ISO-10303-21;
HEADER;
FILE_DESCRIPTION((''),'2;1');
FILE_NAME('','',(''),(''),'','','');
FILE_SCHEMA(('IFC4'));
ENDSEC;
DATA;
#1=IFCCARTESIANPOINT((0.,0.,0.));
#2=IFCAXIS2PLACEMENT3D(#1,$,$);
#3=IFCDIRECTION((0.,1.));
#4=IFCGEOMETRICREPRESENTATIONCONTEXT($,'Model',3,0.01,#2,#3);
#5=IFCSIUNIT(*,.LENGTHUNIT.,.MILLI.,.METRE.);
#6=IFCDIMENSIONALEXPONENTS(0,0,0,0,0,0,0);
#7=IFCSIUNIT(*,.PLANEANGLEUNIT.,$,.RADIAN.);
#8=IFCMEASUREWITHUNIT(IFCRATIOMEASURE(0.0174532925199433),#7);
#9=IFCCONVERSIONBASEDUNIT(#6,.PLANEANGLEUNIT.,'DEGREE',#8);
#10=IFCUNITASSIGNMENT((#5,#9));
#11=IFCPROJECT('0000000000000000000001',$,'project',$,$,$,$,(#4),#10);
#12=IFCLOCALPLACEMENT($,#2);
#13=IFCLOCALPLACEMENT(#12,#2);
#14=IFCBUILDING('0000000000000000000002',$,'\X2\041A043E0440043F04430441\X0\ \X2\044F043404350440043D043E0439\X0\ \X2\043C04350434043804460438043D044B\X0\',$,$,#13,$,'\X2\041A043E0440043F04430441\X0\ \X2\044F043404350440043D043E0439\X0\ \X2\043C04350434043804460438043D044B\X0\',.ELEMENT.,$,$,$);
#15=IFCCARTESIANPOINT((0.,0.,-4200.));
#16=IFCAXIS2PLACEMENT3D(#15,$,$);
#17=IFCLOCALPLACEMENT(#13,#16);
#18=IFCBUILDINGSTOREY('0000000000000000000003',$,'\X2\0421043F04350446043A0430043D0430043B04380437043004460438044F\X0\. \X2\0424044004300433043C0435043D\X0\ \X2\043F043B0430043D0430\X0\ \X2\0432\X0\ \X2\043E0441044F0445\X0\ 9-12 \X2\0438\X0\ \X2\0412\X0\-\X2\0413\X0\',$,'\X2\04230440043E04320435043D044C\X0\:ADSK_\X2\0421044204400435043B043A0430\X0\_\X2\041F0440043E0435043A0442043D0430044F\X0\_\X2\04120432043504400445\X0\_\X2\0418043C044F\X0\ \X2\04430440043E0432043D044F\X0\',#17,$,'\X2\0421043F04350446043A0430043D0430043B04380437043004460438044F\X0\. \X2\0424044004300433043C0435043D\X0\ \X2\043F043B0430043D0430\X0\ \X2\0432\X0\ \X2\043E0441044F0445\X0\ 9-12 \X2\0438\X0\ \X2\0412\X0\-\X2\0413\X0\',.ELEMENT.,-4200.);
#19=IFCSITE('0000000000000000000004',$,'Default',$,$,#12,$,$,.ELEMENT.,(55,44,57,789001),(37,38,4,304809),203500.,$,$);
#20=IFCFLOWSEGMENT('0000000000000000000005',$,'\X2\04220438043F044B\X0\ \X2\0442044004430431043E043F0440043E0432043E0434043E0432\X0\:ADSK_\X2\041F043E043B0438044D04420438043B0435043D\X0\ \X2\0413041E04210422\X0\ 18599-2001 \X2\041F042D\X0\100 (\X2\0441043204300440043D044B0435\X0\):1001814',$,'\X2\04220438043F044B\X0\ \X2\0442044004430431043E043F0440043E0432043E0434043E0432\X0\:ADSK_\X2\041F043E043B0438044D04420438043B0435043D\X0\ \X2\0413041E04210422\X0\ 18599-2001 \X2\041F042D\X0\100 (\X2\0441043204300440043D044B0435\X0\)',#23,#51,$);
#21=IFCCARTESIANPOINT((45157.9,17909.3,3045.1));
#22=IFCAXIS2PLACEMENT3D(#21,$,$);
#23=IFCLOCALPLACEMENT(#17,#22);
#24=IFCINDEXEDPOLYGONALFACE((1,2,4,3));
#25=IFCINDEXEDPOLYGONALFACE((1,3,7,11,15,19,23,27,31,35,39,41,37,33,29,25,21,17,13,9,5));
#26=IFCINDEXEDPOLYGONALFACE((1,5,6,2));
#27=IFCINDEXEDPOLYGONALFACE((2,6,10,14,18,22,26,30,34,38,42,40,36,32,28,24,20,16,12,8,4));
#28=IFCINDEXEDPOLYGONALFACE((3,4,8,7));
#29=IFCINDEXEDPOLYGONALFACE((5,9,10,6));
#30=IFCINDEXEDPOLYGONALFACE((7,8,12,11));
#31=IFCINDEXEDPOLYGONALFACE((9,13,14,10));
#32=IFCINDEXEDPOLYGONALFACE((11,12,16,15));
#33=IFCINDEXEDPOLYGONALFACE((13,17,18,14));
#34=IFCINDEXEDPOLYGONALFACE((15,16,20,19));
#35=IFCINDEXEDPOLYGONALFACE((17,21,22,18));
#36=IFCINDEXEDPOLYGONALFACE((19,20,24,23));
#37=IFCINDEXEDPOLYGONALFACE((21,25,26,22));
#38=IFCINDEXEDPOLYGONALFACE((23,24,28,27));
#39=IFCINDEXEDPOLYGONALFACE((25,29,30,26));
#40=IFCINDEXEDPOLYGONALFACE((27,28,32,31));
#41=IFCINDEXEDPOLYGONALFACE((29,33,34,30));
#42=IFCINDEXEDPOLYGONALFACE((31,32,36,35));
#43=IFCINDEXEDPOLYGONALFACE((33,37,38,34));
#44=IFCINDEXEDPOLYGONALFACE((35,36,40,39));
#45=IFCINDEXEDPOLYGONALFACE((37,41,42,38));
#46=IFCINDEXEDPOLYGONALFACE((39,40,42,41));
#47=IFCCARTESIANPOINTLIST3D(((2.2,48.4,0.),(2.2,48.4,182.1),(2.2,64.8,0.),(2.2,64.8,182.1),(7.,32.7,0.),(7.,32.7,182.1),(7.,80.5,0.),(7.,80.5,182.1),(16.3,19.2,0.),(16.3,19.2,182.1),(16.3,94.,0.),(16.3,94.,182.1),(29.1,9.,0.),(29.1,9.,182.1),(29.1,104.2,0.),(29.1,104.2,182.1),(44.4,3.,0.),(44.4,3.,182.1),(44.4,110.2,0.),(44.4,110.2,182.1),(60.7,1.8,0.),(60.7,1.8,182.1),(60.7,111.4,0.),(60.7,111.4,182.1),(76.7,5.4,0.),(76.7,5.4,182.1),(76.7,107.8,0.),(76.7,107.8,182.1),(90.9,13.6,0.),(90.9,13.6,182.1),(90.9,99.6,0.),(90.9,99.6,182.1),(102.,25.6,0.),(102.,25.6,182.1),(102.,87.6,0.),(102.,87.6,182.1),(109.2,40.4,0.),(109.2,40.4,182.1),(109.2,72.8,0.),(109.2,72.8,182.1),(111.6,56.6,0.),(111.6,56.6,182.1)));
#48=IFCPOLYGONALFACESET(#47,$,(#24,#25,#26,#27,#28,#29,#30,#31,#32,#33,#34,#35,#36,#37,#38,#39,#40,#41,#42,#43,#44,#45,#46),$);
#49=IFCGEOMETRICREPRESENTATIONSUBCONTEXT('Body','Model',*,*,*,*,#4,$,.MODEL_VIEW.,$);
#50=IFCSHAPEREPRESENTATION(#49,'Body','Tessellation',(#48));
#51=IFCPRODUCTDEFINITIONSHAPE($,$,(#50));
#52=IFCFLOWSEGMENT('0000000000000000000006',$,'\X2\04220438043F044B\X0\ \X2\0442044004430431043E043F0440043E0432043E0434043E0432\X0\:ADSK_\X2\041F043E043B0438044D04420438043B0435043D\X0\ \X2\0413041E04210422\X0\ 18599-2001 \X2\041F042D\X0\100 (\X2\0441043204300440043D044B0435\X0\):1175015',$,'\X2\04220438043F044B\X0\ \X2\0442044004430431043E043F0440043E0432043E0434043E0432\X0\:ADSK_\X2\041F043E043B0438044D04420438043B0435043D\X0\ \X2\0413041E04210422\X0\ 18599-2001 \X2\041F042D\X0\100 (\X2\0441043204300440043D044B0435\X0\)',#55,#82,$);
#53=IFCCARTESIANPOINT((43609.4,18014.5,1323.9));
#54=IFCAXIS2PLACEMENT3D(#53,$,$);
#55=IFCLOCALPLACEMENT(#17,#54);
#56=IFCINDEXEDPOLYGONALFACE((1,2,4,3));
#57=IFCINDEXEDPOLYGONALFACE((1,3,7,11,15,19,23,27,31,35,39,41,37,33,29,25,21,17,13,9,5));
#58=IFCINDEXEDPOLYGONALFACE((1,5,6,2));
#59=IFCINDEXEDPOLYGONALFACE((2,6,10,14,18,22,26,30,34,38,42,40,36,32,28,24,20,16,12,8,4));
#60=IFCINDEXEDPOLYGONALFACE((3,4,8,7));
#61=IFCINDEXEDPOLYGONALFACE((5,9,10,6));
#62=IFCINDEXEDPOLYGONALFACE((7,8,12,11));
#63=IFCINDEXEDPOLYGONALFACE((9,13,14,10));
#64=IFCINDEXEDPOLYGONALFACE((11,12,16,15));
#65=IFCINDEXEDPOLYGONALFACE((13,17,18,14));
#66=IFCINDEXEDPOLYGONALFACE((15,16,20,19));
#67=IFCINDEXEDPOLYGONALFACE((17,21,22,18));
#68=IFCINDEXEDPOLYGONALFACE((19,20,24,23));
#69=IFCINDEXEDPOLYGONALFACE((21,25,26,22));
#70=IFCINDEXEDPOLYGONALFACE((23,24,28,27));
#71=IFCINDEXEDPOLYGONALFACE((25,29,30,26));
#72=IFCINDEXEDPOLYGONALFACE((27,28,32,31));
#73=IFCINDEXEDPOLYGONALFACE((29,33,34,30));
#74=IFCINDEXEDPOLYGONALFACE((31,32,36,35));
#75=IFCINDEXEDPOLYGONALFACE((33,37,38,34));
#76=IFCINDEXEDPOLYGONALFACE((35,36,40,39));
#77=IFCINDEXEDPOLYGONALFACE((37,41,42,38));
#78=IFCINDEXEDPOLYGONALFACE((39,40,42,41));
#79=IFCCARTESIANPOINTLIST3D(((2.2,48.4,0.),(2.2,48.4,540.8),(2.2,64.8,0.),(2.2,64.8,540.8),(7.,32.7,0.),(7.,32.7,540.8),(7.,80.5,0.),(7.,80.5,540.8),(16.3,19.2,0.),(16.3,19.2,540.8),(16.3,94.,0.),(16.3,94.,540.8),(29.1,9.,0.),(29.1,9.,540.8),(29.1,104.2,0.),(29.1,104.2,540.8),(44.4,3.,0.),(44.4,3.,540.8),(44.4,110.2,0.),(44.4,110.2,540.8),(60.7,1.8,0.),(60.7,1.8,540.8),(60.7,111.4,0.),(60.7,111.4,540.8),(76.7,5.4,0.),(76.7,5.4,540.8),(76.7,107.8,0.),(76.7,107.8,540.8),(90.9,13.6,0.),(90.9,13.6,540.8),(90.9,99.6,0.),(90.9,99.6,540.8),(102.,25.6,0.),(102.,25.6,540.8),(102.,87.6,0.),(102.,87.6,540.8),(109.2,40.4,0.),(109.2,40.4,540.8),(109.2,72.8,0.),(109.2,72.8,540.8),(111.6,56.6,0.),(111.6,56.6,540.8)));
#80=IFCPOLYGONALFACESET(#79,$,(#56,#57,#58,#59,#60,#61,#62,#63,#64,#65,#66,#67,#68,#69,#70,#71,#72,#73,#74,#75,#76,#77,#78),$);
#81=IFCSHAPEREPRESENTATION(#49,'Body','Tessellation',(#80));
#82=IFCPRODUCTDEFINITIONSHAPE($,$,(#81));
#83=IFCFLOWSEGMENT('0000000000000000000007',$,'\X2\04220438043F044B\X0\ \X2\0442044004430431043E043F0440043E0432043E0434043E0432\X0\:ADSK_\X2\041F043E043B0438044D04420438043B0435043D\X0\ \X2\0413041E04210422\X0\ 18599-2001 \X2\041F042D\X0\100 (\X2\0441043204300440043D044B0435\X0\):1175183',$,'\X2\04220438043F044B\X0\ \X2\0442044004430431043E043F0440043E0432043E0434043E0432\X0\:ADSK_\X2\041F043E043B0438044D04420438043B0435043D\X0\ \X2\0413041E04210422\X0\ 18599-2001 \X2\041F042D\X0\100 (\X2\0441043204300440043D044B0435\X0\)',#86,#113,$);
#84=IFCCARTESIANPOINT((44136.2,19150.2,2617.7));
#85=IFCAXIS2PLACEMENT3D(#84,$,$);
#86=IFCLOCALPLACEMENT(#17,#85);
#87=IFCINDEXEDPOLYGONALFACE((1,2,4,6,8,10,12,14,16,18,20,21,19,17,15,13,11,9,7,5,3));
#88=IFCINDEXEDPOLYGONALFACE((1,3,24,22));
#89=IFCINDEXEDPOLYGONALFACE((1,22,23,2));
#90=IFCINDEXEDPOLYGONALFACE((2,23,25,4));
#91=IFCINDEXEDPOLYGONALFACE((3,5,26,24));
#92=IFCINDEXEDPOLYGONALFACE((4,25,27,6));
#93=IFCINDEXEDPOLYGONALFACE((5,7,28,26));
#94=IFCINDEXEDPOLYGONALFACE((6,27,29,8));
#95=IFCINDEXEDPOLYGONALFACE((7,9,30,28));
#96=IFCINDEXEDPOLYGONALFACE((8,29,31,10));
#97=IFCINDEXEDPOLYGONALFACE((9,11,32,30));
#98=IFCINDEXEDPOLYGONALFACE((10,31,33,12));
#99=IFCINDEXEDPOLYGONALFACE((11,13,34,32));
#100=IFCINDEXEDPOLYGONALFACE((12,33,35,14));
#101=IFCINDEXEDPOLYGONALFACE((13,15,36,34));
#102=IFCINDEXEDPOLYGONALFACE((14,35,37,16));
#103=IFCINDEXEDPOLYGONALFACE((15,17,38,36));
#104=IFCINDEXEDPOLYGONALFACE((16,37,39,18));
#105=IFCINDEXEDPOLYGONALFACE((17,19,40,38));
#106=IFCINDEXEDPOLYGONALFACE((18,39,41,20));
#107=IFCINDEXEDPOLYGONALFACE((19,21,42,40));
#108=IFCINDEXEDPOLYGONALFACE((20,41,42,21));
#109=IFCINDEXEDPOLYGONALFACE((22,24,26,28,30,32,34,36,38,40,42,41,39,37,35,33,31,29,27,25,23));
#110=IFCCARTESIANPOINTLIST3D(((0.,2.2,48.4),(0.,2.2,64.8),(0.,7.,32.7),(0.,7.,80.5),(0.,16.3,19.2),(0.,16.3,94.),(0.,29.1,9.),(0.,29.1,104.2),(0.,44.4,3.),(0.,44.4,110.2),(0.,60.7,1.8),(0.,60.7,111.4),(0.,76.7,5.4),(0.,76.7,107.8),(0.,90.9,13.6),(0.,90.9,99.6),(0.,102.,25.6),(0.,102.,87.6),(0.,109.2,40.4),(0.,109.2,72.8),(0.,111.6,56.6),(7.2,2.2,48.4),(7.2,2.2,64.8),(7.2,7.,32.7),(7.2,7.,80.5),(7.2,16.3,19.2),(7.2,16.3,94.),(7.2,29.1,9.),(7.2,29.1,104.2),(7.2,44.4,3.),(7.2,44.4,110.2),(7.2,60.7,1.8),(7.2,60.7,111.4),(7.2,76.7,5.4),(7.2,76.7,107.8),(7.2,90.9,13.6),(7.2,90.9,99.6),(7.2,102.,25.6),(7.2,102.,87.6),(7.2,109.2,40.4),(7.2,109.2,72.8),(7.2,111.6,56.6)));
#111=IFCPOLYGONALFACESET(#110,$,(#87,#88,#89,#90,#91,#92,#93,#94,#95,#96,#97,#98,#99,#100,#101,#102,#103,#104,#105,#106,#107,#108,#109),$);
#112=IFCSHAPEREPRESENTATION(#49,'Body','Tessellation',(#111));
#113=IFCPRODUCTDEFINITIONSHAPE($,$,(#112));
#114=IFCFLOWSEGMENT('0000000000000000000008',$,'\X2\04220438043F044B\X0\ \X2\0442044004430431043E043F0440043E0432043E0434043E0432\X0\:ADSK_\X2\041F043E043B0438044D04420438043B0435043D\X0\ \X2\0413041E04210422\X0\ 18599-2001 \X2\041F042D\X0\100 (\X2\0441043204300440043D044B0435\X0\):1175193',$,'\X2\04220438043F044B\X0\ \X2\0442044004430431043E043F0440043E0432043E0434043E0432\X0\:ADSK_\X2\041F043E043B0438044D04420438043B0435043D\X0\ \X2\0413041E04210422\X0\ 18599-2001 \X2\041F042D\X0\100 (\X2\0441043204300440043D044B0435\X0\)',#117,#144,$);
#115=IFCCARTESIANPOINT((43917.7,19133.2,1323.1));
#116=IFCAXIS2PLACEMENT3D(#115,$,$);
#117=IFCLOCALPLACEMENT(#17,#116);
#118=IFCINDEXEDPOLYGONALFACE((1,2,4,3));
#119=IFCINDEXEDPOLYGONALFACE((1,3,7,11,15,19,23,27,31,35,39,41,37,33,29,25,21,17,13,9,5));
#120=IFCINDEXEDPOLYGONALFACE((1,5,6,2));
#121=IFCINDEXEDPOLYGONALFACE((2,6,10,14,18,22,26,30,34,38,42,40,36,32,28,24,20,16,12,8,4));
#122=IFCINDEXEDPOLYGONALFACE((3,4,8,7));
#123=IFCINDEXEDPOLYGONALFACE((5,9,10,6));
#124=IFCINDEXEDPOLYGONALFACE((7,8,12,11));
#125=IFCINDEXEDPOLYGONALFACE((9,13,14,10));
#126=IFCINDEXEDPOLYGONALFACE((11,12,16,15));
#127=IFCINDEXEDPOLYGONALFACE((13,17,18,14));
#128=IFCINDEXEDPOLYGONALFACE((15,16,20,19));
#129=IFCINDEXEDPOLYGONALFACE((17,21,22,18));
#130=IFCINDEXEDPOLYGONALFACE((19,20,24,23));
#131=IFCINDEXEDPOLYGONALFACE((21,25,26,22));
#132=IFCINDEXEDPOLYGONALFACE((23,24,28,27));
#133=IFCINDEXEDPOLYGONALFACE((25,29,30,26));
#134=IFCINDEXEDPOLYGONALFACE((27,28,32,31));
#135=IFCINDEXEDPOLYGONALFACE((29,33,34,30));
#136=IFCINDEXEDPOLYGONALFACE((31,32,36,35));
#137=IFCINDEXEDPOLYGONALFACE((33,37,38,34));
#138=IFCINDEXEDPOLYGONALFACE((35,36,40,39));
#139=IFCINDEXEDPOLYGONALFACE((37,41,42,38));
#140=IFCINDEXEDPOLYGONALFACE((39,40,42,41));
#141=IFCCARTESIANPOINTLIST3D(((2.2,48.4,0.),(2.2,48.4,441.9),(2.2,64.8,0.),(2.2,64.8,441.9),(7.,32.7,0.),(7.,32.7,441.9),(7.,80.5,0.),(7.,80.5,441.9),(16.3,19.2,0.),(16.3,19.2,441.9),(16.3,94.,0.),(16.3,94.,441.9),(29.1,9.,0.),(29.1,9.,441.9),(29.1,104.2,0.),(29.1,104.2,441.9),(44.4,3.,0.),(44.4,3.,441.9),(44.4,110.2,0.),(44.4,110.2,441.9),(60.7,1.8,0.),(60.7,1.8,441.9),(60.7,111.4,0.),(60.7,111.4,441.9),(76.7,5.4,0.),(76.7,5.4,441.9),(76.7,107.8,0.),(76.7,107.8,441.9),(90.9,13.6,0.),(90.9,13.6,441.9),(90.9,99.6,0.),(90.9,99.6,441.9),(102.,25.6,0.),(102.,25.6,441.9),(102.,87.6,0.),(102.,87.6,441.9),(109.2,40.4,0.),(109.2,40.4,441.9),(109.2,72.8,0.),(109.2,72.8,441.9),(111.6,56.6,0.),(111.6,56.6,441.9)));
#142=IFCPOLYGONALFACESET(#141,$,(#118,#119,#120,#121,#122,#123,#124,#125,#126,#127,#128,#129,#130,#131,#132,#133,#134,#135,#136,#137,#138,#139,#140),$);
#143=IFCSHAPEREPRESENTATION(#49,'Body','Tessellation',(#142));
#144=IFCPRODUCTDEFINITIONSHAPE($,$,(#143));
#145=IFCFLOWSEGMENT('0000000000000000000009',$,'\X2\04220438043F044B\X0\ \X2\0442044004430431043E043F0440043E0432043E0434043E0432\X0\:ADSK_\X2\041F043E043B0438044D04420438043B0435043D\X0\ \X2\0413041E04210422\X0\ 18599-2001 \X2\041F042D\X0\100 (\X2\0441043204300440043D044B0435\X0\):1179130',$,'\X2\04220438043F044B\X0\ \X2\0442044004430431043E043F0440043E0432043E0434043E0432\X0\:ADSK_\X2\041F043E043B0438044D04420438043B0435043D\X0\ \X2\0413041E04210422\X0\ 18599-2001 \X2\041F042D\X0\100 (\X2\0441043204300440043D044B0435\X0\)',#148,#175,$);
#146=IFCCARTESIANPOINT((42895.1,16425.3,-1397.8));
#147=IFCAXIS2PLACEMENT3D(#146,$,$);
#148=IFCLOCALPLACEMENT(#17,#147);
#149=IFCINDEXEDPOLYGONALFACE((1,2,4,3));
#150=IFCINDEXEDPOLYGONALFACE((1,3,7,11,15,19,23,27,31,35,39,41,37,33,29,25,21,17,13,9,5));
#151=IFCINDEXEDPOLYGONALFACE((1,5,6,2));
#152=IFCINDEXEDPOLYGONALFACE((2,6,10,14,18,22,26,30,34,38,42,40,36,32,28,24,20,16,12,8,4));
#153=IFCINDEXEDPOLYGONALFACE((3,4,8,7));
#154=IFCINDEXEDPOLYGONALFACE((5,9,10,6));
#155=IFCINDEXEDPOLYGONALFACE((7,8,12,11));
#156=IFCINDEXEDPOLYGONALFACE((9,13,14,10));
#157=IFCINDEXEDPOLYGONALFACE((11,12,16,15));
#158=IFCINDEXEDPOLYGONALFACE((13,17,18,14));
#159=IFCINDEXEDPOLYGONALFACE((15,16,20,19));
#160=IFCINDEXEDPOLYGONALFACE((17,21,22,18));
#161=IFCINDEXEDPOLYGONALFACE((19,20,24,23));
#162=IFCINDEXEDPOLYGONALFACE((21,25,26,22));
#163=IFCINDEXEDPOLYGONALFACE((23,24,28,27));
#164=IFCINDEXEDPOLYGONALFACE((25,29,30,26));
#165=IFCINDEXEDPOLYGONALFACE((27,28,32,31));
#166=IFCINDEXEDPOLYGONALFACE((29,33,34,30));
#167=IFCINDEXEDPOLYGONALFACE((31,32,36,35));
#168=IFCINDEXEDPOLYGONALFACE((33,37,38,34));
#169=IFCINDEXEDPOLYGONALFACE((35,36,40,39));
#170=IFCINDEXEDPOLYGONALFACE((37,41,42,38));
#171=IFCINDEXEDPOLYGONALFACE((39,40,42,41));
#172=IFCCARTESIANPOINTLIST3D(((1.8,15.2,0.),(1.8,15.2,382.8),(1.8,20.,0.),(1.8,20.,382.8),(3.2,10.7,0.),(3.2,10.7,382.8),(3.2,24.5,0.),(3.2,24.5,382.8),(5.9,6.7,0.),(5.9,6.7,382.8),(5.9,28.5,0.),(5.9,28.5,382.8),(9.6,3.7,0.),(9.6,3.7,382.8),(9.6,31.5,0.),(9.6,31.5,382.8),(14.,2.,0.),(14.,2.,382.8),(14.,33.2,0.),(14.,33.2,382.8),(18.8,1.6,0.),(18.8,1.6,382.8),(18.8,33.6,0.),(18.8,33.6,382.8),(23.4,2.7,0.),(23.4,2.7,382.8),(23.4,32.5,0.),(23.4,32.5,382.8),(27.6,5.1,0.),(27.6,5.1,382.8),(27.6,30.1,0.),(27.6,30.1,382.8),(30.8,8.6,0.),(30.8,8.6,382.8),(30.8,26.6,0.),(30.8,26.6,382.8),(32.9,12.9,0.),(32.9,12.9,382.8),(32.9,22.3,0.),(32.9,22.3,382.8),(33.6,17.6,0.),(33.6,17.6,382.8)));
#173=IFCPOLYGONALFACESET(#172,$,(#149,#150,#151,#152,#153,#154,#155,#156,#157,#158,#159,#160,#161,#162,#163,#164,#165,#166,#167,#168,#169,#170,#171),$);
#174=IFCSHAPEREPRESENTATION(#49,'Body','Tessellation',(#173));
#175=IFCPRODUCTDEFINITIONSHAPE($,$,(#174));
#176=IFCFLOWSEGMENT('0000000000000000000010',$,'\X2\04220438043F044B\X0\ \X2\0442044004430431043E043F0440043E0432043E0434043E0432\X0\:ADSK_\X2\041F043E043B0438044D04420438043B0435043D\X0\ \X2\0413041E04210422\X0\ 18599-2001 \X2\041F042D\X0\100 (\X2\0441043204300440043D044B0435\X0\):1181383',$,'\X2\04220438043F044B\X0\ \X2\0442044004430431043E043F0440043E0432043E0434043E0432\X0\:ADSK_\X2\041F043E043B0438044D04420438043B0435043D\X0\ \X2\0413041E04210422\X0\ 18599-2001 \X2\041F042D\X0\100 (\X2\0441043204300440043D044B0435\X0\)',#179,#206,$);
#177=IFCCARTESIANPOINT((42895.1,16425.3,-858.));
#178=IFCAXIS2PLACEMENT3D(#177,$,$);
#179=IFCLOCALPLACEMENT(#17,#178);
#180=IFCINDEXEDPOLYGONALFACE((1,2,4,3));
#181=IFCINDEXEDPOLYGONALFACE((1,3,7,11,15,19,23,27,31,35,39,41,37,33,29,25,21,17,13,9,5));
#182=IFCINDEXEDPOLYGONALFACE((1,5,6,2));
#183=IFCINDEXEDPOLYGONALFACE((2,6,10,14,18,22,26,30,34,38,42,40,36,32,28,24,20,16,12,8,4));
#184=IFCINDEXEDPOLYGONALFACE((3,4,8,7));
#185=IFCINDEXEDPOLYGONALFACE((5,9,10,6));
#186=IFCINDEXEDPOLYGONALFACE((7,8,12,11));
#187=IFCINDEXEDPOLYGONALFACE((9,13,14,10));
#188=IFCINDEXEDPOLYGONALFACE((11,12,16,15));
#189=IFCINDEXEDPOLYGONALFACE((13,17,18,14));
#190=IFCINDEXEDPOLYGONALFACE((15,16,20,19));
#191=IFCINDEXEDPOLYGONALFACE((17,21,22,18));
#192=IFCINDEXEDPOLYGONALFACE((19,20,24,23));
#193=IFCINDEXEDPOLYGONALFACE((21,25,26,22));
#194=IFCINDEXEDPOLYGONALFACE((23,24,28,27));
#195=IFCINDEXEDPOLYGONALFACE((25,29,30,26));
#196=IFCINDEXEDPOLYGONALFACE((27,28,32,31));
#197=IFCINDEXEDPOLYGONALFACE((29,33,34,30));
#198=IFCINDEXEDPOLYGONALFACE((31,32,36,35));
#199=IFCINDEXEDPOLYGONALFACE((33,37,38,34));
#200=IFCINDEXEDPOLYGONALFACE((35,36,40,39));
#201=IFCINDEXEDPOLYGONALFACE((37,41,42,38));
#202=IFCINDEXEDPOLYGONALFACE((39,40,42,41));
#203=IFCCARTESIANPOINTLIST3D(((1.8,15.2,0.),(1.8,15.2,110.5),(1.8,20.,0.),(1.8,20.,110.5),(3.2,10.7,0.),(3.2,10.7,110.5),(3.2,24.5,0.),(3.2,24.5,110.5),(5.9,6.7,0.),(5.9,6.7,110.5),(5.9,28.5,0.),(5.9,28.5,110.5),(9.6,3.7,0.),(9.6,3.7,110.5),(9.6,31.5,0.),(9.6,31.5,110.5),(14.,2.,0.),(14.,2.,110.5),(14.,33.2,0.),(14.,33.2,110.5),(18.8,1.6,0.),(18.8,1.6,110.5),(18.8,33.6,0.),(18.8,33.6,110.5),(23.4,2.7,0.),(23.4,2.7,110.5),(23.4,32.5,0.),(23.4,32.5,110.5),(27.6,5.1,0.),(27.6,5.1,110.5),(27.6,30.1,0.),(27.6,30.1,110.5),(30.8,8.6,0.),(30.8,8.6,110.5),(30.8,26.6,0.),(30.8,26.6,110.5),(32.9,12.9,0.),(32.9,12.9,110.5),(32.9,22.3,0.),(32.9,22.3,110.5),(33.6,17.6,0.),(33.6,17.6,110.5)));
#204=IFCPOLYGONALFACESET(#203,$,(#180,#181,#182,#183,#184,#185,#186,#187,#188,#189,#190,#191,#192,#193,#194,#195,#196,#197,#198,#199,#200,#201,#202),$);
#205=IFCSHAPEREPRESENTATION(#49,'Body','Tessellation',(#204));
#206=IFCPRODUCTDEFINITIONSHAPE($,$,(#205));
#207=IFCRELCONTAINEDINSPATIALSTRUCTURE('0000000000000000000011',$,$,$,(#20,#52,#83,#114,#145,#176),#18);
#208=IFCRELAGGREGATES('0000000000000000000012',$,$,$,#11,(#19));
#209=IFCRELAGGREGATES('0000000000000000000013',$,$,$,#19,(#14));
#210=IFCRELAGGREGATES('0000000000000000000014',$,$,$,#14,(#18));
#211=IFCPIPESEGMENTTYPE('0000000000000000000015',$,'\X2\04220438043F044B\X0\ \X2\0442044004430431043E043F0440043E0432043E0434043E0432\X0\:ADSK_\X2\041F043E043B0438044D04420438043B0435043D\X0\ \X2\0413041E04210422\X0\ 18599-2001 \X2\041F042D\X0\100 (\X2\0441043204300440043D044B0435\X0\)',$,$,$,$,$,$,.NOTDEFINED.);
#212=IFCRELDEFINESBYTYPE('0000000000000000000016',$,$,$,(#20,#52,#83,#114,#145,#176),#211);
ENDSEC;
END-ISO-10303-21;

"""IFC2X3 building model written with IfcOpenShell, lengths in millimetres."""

from ifc_helpers import new_model, entity, si_unit, converted_unit, direction, frame, origin, origin_2d_with_axis, place, context, subcontext, project, spatial, circle, extrude, type_object, element, save


model = new_model("IFC2X3")

# Units and contexts
model_context = context("Model", 3, precision=0.01, world=origin(), true_north=direction((0.0, 1.0)))
body_context = subcontext(model_context, "Body", "Model", "MODEL_VIEW")
ifc_project = project(units=[si_unit("LENGTHUNIT", "METRE", prefix="MILLI"), converted_unit("PLANEANGLEUNIT", "DEGREE", entity("IfcRatioMeasure", 0.0174532925199433), si_unit("PLANEANGLEUNIT", "RADIAN"), dimensions=[0, 0, 0, 0, 0, 0, 0])], contexts=[model_context])

# Site, building, storey
site_placement = place(None, origin())
site = spatial("IfcSite", under=ifc_project, at=site_placement, Name="Default", CompositionType="ELEMENT", RefLatitude=(55, 44, 57, 789001), RefLongitude=(37, 38, 4, 304809), RefElevation=203500.0)
building_placement = place(site_placement, origin())
building = spatial("IfcBuilding", under=site, at=building_placement, Name="Корпус ядерной медицины", LongName="Корпус ядерной медицины", CompositionType="ELEMENT")
storey_placement = place(building_placement, frame((0.0, 0.0, -4200.0)))
storey = spatial("IfcBuildingStorey", under=building, at=storey_placement, Name="Спецканализация. Фрагмен плана в осях 9-12 и В-Г", ObjectType="Уровень:ADSK_Стрелка_Проектная_Вверх_Имя уровня", LongName="Спецканализация. Фрагмен плана в осях 9-12 и В-Г", CompositionType="ELEMENT", Elevation=-4200.0)

# Flow segments
pipe_segment_type = type_object("IfcPipeSegmentType", Name="Типы трубопроводов:ADSK_Полиэтилен ГОСТ 18599-2001 ПЭ100 (сварные)", PredefinedType="NOTDEFINED")
flow_segment_1_placement = place(storey_placement, frame((45157.9, 17909.3, 3045.1)))
element("IfcFlowSegment", 1, at=flow_segment_1_placement, inside=storey, type_object=pipe_segment_type, Name="Типы трубопроводов:ADSK_Полиэтилен ГОСТ 18599-2001 ПЭ100 (сварные):1001814", ObjectType="Типы трубопроводов:ADSK_Полиэтилен ГОСТ 18599-2001 ПЭ100 (сварные)", context=body_context, shape_type="SweptSolid", body=[
    extrude(circle(Radius=55.0, at=origin_2d_with_axis()), frame((56.6, 56.6, 0.0)), (0.0, 0.0, 1.0), 182.1),
])
flow_segment_2_placement = place(storey_placement, frame((43609.4, 18014.5, 1323.9)))
element("IfcFlowSegment", 2, at=flow_segment_2_placement, inside=storey, type_object=pipe_segment_type, Name="Типы трубопроводов:ADSK_Полиэтилен ГОСТ 18599-2001 ПЭ100 (сварные):1175015", ObjectType="Типы трубопроводов:ADSK_Полиэтилен ГОСТ 18599-2001 ПЭ100 (сварные)", context=body_context, shape_type="SweptSolid", body=[
    extrude(circle(Radius=55.0, at=origin_2d_with_axis()), frame((56.6, 56.6, 0.0)), (0.0, 0.0, 1.0), 540.8),
])
flow_segment_3_placement = place(storey_placement, frame((44136.2, 19150.2, 2617.7)))
element("IfcFlowSegment", 3, at=flow_segment_3_placement, inside=storey, type_object=pipe_segment_type, Name="Типы трубопроводов:ADSK_Полиэтилен ГОСТ 18599-2001 ПЭ100 (сварные):1175183", ObjectType="Типы трубопроводов:ADSK_Полиэтилен ГОСТ 18599-2001 ПЭ100 (сварные)", context=body_context, shape_type="SweptSolid", body=[
    extrude(circle(Radius=55.0, at=origin_2d_with_axis()), frame((0.0, 56.6, 56.6), z_axis=(1.0, 0.000059, 0.0), x_axis=(-0.000059, 1.0, 0.0)), (0.0, 0.0, 1.0), 7.2),
])
flow_segment_4_placement = place(storey_placement, frame((43917.7, 19133.2, 1323.1)))
element("IfcFlowSegment", 4, at=flow_segment_4_placement, inside=storey, type_object=pipe_segment_type, Name="Типы трубопроводов:ADSK_Полиэтилен ГОСТ 18599-2001 ПЭ100 (сварные):1175193", ObjectType="Типы трубопроводов:ADSK_Полиэтилен ГОСТ 18599-2001 ПЭ100 (сварные)", context=body_context, shape_type="SweptSolid", body=[
    extrude(circle(Radius=55.0, at=origin_2d_with_axis()), frame((56.6, 56.6, 0.0)), (0.0, 0.0, 1.0), 441.9),
])
flow_segment_5_placement = place(storey_placement, frame((42895.1, 16425.3, -1397.8)))
element("IfcFlowSegment", 5, at=flow_segment_5_placement, inside=storey, type_object=pipe_segment_type, Name="Типы трубопроводов:ADSK_Полиэтилен ГОСТ 18599-2001 ПЭ100 (сварные):1179130", ObjectType="Типы трубопроводов:ADSK_Полиэтилен ГОСТ 18599-2001 ПЭ100 (сварные)", context=body_context, shape_type="SweptSolid", body=[
    extrude(circle(Radius=16.0, at=origin_2d_with_axis()), frame((17.6, 17.6, 0.0)), (0.0, 0.0, 1.0), 382.8),
])
flow_segment_6_placement = place(storey_placement, frame((42895.1, 16425.3, -858.0)))
element("IfcFlowSegment", 6, at=flow_segment_6_placement, inside=storey, type_object=pipe_segment_type, Name="Типы трубопроводов:ADSK_Полиэтилен ГОСТ 18599-2001 ПЭ100 (сварные):1181383", ObjectType="Типы трубопроводов:ADSK_Полиэтилен ГОСТ 18599-2001 ПЭ100 (сварные)", context=body_context, shape_type="SweptSolid", body=[
    extrude(circle(Radius=16.0, at=origin_2d_with_axis()), frame((17.6, 17.6, 0.0)), (0.0, 0.0, 1.0), 110.5),
])

save(model, "model.ifc")
